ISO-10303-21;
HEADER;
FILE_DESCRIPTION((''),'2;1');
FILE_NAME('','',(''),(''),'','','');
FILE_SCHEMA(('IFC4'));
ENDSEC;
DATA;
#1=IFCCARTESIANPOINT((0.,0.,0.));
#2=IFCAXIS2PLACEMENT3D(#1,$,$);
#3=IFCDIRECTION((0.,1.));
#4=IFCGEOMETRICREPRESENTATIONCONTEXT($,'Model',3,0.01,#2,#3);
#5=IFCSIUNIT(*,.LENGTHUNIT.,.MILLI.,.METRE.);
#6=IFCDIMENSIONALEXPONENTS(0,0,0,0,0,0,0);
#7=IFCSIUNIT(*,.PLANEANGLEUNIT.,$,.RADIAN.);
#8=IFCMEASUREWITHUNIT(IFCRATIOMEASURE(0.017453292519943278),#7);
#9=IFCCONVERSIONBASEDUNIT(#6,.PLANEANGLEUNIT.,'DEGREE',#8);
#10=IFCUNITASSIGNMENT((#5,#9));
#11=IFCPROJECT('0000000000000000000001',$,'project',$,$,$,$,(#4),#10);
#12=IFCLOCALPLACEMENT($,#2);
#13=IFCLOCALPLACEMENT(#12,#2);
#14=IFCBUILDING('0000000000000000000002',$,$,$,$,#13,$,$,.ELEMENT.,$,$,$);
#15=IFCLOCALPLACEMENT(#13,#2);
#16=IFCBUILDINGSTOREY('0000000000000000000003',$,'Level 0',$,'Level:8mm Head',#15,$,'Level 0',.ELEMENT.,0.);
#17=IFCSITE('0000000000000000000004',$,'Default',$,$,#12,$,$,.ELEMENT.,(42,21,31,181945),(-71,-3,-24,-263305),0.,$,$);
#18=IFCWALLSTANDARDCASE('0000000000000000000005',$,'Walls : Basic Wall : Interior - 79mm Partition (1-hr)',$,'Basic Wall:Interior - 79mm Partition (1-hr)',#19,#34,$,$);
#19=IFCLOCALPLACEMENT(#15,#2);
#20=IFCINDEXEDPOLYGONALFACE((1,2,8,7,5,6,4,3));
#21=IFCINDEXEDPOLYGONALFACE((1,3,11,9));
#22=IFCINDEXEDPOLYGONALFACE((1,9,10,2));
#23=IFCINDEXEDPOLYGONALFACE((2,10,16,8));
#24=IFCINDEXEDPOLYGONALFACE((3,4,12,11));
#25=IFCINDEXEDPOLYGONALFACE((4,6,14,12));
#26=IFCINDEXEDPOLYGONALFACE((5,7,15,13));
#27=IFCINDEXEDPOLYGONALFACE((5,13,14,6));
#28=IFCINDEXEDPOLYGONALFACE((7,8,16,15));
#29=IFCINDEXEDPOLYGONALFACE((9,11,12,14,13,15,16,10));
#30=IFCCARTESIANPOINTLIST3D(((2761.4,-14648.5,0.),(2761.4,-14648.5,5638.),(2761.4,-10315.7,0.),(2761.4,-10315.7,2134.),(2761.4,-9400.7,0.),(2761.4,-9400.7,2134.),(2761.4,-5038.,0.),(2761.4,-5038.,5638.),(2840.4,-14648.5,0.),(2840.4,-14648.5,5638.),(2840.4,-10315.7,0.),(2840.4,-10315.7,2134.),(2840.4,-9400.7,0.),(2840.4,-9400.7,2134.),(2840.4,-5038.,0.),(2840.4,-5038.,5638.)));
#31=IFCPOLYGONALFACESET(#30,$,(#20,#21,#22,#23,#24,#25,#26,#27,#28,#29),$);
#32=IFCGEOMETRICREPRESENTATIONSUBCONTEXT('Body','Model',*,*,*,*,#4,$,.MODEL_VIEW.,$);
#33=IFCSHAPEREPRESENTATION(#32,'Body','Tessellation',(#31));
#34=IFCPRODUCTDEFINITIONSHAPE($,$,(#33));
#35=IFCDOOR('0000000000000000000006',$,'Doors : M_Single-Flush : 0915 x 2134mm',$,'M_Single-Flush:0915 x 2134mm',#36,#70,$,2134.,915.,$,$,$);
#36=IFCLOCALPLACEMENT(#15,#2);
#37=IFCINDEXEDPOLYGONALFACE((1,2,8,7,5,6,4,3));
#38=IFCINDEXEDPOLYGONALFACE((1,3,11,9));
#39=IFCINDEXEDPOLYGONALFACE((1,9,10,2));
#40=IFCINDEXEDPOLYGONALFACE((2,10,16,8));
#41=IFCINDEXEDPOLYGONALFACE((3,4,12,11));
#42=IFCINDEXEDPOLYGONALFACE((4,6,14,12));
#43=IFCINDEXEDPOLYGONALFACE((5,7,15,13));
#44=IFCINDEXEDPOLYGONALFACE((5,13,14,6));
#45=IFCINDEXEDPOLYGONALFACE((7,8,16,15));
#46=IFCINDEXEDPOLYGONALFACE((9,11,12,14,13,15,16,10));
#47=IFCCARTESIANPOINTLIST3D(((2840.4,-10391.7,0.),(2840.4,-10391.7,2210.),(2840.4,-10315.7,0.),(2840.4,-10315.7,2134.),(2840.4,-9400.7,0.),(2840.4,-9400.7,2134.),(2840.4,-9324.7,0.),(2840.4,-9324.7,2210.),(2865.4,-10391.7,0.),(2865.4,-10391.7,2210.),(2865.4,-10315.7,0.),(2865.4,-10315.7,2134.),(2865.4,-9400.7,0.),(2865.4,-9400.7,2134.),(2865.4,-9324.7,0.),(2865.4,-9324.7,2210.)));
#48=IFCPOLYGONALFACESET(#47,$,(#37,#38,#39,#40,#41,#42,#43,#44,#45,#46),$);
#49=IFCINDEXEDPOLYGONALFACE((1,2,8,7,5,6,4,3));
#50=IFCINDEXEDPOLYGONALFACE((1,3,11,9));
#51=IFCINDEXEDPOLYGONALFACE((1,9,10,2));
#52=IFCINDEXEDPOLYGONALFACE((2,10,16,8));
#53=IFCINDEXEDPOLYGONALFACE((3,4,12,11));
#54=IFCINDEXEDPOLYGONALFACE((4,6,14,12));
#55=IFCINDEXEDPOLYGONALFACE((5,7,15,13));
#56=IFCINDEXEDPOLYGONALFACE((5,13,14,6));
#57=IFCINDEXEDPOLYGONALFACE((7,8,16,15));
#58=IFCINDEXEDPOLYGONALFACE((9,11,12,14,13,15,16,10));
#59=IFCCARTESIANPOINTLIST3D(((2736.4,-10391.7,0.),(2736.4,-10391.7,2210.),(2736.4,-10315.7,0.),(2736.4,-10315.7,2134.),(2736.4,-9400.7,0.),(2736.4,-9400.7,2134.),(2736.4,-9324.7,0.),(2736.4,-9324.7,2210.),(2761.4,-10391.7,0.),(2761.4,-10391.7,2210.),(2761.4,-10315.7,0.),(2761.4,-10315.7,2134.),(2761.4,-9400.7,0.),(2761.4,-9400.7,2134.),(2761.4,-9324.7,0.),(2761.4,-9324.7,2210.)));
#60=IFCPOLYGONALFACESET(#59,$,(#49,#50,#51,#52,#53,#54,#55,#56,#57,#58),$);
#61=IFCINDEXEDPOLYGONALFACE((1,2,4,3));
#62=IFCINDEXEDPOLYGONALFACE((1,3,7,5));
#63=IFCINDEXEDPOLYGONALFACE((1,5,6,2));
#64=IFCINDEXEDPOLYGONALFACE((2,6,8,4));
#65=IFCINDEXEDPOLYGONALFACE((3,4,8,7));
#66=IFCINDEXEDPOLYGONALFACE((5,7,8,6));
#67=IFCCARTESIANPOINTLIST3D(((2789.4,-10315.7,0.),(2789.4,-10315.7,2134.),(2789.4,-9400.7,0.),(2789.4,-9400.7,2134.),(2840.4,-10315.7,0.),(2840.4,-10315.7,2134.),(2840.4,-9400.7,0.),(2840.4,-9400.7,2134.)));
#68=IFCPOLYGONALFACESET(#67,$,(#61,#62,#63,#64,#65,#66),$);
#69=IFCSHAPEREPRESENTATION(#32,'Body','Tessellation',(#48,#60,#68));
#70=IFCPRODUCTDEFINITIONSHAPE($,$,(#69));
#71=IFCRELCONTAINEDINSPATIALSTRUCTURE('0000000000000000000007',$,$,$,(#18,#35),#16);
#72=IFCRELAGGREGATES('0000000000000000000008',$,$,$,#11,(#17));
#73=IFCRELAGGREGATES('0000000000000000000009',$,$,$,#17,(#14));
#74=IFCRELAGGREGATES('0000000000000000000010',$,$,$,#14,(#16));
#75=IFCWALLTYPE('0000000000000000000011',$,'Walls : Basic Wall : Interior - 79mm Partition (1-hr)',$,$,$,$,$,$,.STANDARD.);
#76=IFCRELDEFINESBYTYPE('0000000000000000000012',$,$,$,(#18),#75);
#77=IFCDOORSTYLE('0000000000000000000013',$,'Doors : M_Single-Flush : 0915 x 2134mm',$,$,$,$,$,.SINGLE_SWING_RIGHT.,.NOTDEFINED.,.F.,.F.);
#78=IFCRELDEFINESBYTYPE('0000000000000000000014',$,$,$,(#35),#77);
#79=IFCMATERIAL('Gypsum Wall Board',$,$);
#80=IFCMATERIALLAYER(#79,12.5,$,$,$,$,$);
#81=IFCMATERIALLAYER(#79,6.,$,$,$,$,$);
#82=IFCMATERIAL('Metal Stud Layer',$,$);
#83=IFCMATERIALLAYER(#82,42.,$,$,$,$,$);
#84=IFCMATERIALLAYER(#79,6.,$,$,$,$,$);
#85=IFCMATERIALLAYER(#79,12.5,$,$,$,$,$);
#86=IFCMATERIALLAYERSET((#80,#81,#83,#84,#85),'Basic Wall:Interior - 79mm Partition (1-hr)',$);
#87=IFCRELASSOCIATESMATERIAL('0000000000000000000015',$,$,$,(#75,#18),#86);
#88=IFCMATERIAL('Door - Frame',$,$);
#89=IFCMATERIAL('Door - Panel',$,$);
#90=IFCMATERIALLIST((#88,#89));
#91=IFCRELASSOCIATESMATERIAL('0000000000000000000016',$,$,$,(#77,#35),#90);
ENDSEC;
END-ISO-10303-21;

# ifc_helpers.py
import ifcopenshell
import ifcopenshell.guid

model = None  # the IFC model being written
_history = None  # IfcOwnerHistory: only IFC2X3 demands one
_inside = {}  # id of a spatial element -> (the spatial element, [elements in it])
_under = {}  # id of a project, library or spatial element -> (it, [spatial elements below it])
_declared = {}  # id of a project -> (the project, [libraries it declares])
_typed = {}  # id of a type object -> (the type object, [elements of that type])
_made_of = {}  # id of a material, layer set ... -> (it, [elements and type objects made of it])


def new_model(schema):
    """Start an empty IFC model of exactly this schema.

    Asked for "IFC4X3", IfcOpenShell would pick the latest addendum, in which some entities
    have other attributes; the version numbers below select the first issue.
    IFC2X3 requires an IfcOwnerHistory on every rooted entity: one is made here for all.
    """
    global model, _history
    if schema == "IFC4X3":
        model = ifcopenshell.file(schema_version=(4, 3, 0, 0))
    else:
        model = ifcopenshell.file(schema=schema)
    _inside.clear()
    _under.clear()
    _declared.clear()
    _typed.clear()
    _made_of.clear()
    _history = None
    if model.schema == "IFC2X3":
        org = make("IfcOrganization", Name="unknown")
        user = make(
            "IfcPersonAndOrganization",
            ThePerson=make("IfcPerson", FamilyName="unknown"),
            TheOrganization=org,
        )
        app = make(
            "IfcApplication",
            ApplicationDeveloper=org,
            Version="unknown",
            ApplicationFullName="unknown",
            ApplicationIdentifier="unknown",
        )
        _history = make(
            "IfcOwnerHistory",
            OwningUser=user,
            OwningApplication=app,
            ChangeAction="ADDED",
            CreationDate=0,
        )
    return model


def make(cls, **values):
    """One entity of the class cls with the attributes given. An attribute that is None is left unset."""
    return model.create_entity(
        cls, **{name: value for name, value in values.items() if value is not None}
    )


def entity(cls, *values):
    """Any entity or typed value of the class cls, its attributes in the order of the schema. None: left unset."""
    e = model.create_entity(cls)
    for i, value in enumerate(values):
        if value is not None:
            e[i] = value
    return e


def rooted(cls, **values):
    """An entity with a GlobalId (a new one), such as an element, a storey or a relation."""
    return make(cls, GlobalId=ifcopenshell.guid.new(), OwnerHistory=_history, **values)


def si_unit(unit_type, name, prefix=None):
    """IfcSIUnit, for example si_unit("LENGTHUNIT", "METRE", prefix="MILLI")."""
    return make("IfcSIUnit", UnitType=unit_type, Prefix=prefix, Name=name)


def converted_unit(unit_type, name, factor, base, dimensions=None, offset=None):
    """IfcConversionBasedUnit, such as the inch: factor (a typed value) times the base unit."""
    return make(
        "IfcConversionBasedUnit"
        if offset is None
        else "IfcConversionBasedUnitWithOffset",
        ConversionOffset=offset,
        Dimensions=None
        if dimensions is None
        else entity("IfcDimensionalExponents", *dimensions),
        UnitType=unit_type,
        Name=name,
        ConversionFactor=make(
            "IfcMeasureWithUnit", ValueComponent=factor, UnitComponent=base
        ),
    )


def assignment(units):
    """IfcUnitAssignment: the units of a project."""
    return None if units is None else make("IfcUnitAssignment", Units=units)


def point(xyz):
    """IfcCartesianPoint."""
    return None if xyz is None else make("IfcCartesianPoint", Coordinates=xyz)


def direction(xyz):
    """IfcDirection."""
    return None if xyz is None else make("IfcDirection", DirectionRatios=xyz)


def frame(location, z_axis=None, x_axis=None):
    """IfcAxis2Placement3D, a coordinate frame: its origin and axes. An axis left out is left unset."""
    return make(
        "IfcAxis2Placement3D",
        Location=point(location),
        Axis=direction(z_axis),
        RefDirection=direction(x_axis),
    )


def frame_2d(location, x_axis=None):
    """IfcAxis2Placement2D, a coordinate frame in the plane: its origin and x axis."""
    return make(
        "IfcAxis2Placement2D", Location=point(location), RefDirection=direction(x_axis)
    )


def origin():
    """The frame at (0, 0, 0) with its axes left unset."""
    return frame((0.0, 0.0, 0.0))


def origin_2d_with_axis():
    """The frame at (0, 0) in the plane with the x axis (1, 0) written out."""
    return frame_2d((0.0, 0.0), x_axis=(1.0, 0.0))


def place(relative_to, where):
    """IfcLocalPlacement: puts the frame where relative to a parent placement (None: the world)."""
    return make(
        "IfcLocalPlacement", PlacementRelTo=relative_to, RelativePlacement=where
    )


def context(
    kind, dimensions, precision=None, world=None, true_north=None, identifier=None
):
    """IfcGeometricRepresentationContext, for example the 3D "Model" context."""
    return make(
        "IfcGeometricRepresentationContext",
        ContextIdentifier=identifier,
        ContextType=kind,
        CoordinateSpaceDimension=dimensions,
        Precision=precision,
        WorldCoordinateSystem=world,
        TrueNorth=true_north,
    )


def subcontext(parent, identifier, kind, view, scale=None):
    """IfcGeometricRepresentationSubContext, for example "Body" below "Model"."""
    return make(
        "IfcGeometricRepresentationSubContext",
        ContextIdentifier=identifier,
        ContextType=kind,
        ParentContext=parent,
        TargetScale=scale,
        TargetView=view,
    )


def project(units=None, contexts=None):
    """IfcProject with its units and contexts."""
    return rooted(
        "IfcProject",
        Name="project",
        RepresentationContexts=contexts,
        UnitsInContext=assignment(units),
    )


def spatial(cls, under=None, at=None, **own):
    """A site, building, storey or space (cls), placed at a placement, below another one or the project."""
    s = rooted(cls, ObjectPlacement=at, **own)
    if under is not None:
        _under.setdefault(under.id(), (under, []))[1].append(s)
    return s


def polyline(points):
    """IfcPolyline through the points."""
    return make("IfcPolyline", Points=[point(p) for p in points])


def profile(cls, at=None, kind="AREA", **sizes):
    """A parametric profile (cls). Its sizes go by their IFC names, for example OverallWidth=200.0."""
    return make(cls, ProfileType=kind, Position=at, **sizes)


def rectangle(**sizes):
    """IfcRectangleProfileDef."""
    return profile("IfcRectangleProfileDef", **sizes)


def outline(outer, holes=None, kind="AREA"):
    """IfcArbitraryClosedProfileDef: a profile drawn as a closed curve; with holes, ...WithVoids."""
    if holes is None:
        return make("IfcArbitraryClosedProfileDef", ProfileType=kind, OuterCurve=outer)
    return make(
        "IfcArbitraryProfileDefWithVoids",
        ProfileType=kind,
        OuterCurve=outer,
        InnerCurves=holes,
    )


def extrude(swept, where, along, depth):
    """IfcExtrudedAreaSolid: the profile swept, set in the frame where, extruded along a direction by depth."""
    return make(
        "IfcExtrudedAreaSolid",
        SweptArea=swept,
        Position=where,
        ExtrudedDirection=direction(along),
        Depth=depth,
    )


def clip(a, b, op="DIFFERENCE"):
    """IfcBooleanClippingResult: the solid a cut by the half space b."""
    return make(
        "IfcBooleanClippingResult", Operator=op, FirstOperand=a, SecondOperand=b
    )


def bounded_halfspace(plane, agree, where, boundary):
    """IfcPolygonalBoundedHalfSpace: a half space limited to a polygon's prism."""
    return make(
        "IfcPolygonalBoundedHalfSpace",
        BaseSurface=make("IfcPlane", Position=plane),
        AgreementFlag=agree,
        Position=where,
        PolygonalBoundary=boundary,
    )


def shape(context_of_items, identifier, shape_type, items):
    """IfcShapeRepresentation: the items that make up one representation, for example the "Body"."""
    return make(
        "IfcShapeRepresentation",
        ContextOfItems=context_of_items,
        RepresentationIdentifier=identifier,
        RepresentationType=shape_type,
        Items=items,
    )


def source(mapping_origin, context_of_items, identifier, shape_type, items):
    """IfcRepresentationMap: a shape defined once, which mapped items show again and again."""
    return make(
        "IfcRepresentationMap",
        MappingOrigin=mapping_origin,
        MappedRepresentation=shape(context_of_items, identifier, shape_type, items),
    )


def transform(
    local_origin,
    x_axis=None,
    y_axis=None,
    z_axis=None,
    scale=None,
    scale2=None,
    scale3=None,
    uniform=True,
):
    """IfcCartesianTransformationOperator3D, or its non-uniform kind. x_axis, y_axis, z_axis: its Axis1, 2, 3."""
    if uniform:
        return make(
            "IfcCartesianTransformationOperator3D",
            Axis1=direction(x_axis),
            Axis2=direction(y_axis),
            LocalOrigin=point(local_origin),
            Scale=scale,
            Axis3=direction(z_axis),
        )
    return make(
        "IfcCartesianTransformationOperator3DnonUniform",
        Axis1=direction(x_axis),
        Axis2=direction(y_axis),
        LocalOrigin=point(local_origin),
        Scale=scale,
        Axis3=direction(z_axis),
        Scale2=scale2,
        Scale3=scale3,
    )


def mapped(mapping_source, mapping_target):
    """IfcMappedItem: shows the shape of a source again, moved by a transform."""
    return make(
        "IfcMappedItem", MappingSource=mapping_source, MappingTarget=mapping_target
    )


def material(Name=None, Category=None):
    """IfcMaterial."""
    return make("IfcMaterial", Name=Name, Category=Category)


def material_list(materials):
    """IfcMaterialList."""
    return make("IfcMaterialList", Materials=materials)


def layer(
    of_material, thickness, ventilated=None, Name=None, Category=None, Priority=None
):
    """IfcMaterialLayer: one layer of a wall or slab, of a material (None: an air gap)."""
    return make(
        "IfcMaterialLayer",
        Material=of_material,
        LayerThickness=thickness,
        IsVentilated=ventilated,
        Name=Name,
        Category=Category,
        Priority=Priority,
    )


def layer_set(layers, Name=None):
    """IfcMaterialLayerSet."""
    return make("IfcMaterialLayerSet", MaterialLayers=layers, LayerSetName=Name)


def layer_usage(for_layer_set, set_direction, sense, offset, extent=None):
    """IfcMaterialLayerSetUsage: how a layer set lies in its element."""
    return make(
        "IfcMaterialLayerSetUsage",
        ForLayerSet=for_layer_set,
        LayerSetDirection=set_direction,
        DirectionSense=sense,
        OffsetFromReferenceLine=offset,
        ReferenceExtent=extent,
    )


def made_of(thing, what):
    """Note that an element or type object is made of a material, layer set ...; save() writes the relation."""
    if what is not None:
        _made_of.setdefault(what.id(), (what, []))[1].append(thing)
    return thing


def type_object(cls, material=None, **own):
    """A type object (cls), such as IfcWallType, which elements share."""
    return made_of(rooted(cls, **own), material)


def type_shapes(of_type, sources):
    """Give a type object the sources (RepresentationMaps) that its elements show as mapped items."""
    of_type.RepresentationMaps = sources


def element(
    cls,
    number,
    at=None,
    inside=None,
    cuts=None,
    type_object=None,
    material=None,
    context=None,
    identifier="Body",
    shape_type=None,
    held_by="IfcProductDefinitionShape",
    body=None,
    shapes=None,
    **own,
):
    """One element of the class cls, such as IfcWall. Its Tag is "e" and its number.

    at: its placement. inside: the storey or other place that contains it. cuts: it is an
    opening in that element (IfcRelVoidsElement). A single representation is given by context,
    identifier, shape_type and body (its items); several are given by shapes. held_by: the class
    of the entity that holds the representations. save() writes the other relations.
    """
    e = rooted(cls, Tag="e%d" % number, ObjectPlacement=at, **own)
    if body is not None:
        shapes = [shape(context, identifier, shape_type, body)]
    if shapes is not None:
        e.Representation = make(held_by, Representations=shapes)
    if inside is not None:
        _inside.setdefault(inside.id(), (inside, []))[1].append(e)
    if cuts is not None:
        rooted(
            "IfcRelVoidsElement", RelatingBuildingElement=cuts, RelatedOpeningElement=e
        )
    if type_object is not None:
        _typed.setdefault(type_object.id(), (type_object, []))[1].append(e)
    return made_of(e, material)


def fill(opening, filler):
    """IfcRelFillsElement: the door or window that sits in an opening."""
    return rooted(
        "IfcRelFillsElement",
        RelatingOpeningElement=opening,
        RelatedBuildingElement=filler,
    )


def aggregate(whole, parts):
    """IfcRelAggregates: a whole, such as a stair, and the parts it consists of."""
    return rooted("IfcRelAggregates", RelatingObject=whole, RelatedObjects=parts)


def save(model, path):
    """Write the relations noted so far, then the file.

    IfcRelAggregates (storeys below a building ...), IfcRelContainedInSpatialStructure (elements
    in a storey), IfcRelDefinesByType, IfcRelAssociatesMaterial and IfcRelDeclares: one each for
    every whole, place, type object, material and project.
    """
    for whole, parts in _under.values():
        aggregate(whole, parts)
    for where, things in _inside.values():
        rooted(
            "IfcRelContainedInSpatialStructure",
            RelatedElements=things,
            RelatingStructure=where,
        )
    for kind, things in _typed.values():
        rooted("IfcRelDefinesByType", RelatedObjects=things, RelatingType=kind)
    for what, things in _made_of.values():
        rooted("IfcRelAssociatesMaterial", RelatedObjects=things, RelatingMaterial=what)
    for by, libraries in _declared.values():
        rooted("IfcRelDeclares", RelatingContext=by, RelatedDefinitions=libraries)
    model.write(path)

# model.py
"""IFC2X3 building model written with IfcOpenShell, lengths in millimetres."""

from ifc_helpers import new_model, entity, si_unit, converted_unit, direction, frame, frame_2d, origin, origin_2d_with_axis, place, context, subcontext, project, spatial, polyline, rectangle, outline, extrude, clip, bounded_halfspace, source, transform, mapped, material, material_list, layer, layer_set, layer_usage, type_object, type_shapes, element, fill, save


model = new_model("IFC2X3")

# Units and contexts
model_context = context("Model", 3, precision=0.01, world=origin(), true_north=direction((0.0, 1.0)))
body_context = subcontext(model_context, "Body", "Model", "MODEL_VIEW")
ifc_project = project(units=[si_unit("LENGTHUNIT", "METRE", prefix="MILLI"), converted_unit("PLANEANGLEUNIT", "DEGREE", entity("IfcRatioMeasure", 0.017453292519943278), si_unit("PLANEANGLEUNIT", "RADIAN"), dimensions=[0, 0, 0, 0, 0, 0, 0])], contexts=[model_context])

# Site, building, storey
site_placement = place(None, origin())
site = spatial("IfcSite", under=ifc_project, at=site_placement, Name="Default", CompositionType="ELEMENT", RefLatitude=(42, 21, 31, 181945), RefLongitude=(-71, -3, -24, -263305), RefElevation=0.0)
building_placement = place(site_placement, origin())
building = spatial("IfcBuilding", under=site, at=building_placement, CompositionType="ELEMENT")
storey_placement = place(building_placement, origin())
storey = spatial("IfcBuildingStorey", under=building, at=storey_placement, Name="Level 0", ObjectType="Level:8mm Head", LongName="Level 0", CompositionType="ELEMENT", Elevation=0.0)

# Shared definitions
ifc_material_1 = material(Name="Metal Stud Layer")
ifc_material_2 = material(Name="Gypsum Wall Board")

# Shared definitions
ifc_material_3 = material(Name="Door - Frame")
ifc_material_4 = material(Name="Door - Panel")
ifc_material_list = material_list([ifc_material_3, ifc_material_4])

# Wall, opening, door
ifc_layer_1 = layer(ifc_material_2, 12.5)
ifc_layer_2 = layer(ifc_material_2, 6.0)
ifc_layer_3 = layer(ifc_material_1, 42.0)
ifc_layer_4 = layer(ifc_material_2, 6.0)
ifc_layer_5 = layer(ifc_material_2, 12.5)
ifc_layer_set_1 = layer_set([ifc_layer_1, ifc_layer_2, ifc_layer_3, ifc_layer_4, ifc_layer_5], Name="Basic Wall:Interior - 79mm Partition (1-hr)")
ifc_layer_usage_1 = layer_usage(ifc_layer_set_1, "AXIS2", "NEGATIVE", 39.5)
wall_type_1 = type_object("IfcWallType", Name="Walls : Basic Wall : Interior - 79mm Partition (1-hr)", PredefinedType="STANDARD", material=ifc_layer_set_1)
door_style_1 = type_object("IfcDoorStyle", Name="Doors : M_Single-Flush : 0915 x 2134mm", ConstructionType="NOTDEFINED", OperationType="SINGLE_SWING_RIGHT", ParameterTakesPrecedence=False, Sizeable=False, material=ifc_material_list)
shared_shape_1 = source(origin(), body_context, "Body", "SweptSolid", [
    extrude(outline(polyline([(-533.5, -1124.0), (533.5, -1124.0), (533.5, 1086.0), (457.5, 1086.0), (457.5, -1048.0), (-457.5, -1048.0), (-457.5, 1086.0), (-533.5, 1086.0), (-533.5, -1124.0)])), frame((457.5, 79.0, 1086.0), z_axis=(0.0, 1.0, 0.0), x_axis=(1.0, 0.0, 0.0)), (0.0, 0.0, 1.0), 25.0),
    extrude(outline(polyline([(-1124.0, -533.5), (1086.0, -533.5), (1086.0, -457.5), (-1048.0, -457.5), (-1048.0, 457.5), (1086.0, 457.5), (1086.0, 533.5), (-1124.0, 533.5), (-1124.0, -533.5)])), frame((457.5, -25.0, 1086.0), z_axis=(0.0, 1.0, 0.0), x_axis=(0.0, 0.0, -1.0)), (0.0, 0.0, 1.0), 25.0),
    extrude(rectangle(XDim=51.0, YDim=915.0, at=origin_2d_with_axis()), frame((457.5, 53.5, 0.0), z_axis=(0.0, 0.0, 1.0), x_axis=(0.0, 1.0, 0.0)), (0.0, 0.0, 1.0), 2134.0),
])
type_shapes(door_style_1, [shared_shape_1])
wall_1_placement = place(storey_placement, frame((2800.9, -5038.0, 0.0), z_axis=(0.0, 0.0, 1.0), x_axis=(0.0, -1.0, 0.0)))
wall_1 = element("IfcWallStandardCase", 1, at=wall_1_placement, inside=storey, type_object=wall_type_1, material=ifc_layer_usage_1, Name="Walls : Basic Wall : Interior - 79mm Partition (1-hr)", ObjectType="Basic Wall:Interior - 79mm Partition (1-hr)", context=body_context, shape_type="Clipping", body=[
    clip(extrude(rectangle(XDim=9610.5, YDim=79.0, at=frame_2d((4805.3, 0.0), x_axis=(-1.0, 0.0))), origin(), (0.0, 0.0, 1.0), 5638.0), bounded_halfspace(frame((0.0, -39.5, 5638.0), z_axis=(0.0, 0.0, -1.0), x_axis=(1.0, 0.0, 0.0)), True, frame((0.0, -39.5, 5638.0)), polyline([(0.0, 0.0), (2929280.4, 0.0), (2929280.4, 24079.2), (0.0, 24079.2), (0.0, 0.0)]))),
])
opening_1_placement = place(wall_1_placement, frame((4362.6, -39.5, 0.0)))
opening_1 = element("IfcOpeningElement", 2, at=opening_1_placement, cuts=wall_1, ObjectType="Opening", context=body_context, shape_type="SweptSolid", body=[
    extrude(rectangle(XDim=915.0, YDim=2134.0, at=frame_2d((1067.0, 457.5), x_axis=(0.0, 1.0))), frame((0.0, 0.0, 0.0), z_axis=(0.0, 1.0, 0.0), x_axis=(0.0, 0.0, 1.0)), (0.0, 0.0, 1.0), 79.0),
])
door_1_placement = place(opening_1_placement, origin())
door_1 = element("IfcDoor", 3, at=door_1_placement, inside=storey, type_object=door_style_1, material=ifc_material_list, Name="Doors : M_Single-Flush : 0915 x 2134mm", ObjectType="M_Single-Flush:0915 x 2134mm", OverallHeight=2134.0, OverallWidth=915.0, context=body_context, shape_type="MappedRepresentation", body=[
    mapped(shared_shape_1, transform((0.0, 0.0, 0.0), scale=1.0)),
])
fill(opening_1, door_1)

save(model, "model.ifc")
